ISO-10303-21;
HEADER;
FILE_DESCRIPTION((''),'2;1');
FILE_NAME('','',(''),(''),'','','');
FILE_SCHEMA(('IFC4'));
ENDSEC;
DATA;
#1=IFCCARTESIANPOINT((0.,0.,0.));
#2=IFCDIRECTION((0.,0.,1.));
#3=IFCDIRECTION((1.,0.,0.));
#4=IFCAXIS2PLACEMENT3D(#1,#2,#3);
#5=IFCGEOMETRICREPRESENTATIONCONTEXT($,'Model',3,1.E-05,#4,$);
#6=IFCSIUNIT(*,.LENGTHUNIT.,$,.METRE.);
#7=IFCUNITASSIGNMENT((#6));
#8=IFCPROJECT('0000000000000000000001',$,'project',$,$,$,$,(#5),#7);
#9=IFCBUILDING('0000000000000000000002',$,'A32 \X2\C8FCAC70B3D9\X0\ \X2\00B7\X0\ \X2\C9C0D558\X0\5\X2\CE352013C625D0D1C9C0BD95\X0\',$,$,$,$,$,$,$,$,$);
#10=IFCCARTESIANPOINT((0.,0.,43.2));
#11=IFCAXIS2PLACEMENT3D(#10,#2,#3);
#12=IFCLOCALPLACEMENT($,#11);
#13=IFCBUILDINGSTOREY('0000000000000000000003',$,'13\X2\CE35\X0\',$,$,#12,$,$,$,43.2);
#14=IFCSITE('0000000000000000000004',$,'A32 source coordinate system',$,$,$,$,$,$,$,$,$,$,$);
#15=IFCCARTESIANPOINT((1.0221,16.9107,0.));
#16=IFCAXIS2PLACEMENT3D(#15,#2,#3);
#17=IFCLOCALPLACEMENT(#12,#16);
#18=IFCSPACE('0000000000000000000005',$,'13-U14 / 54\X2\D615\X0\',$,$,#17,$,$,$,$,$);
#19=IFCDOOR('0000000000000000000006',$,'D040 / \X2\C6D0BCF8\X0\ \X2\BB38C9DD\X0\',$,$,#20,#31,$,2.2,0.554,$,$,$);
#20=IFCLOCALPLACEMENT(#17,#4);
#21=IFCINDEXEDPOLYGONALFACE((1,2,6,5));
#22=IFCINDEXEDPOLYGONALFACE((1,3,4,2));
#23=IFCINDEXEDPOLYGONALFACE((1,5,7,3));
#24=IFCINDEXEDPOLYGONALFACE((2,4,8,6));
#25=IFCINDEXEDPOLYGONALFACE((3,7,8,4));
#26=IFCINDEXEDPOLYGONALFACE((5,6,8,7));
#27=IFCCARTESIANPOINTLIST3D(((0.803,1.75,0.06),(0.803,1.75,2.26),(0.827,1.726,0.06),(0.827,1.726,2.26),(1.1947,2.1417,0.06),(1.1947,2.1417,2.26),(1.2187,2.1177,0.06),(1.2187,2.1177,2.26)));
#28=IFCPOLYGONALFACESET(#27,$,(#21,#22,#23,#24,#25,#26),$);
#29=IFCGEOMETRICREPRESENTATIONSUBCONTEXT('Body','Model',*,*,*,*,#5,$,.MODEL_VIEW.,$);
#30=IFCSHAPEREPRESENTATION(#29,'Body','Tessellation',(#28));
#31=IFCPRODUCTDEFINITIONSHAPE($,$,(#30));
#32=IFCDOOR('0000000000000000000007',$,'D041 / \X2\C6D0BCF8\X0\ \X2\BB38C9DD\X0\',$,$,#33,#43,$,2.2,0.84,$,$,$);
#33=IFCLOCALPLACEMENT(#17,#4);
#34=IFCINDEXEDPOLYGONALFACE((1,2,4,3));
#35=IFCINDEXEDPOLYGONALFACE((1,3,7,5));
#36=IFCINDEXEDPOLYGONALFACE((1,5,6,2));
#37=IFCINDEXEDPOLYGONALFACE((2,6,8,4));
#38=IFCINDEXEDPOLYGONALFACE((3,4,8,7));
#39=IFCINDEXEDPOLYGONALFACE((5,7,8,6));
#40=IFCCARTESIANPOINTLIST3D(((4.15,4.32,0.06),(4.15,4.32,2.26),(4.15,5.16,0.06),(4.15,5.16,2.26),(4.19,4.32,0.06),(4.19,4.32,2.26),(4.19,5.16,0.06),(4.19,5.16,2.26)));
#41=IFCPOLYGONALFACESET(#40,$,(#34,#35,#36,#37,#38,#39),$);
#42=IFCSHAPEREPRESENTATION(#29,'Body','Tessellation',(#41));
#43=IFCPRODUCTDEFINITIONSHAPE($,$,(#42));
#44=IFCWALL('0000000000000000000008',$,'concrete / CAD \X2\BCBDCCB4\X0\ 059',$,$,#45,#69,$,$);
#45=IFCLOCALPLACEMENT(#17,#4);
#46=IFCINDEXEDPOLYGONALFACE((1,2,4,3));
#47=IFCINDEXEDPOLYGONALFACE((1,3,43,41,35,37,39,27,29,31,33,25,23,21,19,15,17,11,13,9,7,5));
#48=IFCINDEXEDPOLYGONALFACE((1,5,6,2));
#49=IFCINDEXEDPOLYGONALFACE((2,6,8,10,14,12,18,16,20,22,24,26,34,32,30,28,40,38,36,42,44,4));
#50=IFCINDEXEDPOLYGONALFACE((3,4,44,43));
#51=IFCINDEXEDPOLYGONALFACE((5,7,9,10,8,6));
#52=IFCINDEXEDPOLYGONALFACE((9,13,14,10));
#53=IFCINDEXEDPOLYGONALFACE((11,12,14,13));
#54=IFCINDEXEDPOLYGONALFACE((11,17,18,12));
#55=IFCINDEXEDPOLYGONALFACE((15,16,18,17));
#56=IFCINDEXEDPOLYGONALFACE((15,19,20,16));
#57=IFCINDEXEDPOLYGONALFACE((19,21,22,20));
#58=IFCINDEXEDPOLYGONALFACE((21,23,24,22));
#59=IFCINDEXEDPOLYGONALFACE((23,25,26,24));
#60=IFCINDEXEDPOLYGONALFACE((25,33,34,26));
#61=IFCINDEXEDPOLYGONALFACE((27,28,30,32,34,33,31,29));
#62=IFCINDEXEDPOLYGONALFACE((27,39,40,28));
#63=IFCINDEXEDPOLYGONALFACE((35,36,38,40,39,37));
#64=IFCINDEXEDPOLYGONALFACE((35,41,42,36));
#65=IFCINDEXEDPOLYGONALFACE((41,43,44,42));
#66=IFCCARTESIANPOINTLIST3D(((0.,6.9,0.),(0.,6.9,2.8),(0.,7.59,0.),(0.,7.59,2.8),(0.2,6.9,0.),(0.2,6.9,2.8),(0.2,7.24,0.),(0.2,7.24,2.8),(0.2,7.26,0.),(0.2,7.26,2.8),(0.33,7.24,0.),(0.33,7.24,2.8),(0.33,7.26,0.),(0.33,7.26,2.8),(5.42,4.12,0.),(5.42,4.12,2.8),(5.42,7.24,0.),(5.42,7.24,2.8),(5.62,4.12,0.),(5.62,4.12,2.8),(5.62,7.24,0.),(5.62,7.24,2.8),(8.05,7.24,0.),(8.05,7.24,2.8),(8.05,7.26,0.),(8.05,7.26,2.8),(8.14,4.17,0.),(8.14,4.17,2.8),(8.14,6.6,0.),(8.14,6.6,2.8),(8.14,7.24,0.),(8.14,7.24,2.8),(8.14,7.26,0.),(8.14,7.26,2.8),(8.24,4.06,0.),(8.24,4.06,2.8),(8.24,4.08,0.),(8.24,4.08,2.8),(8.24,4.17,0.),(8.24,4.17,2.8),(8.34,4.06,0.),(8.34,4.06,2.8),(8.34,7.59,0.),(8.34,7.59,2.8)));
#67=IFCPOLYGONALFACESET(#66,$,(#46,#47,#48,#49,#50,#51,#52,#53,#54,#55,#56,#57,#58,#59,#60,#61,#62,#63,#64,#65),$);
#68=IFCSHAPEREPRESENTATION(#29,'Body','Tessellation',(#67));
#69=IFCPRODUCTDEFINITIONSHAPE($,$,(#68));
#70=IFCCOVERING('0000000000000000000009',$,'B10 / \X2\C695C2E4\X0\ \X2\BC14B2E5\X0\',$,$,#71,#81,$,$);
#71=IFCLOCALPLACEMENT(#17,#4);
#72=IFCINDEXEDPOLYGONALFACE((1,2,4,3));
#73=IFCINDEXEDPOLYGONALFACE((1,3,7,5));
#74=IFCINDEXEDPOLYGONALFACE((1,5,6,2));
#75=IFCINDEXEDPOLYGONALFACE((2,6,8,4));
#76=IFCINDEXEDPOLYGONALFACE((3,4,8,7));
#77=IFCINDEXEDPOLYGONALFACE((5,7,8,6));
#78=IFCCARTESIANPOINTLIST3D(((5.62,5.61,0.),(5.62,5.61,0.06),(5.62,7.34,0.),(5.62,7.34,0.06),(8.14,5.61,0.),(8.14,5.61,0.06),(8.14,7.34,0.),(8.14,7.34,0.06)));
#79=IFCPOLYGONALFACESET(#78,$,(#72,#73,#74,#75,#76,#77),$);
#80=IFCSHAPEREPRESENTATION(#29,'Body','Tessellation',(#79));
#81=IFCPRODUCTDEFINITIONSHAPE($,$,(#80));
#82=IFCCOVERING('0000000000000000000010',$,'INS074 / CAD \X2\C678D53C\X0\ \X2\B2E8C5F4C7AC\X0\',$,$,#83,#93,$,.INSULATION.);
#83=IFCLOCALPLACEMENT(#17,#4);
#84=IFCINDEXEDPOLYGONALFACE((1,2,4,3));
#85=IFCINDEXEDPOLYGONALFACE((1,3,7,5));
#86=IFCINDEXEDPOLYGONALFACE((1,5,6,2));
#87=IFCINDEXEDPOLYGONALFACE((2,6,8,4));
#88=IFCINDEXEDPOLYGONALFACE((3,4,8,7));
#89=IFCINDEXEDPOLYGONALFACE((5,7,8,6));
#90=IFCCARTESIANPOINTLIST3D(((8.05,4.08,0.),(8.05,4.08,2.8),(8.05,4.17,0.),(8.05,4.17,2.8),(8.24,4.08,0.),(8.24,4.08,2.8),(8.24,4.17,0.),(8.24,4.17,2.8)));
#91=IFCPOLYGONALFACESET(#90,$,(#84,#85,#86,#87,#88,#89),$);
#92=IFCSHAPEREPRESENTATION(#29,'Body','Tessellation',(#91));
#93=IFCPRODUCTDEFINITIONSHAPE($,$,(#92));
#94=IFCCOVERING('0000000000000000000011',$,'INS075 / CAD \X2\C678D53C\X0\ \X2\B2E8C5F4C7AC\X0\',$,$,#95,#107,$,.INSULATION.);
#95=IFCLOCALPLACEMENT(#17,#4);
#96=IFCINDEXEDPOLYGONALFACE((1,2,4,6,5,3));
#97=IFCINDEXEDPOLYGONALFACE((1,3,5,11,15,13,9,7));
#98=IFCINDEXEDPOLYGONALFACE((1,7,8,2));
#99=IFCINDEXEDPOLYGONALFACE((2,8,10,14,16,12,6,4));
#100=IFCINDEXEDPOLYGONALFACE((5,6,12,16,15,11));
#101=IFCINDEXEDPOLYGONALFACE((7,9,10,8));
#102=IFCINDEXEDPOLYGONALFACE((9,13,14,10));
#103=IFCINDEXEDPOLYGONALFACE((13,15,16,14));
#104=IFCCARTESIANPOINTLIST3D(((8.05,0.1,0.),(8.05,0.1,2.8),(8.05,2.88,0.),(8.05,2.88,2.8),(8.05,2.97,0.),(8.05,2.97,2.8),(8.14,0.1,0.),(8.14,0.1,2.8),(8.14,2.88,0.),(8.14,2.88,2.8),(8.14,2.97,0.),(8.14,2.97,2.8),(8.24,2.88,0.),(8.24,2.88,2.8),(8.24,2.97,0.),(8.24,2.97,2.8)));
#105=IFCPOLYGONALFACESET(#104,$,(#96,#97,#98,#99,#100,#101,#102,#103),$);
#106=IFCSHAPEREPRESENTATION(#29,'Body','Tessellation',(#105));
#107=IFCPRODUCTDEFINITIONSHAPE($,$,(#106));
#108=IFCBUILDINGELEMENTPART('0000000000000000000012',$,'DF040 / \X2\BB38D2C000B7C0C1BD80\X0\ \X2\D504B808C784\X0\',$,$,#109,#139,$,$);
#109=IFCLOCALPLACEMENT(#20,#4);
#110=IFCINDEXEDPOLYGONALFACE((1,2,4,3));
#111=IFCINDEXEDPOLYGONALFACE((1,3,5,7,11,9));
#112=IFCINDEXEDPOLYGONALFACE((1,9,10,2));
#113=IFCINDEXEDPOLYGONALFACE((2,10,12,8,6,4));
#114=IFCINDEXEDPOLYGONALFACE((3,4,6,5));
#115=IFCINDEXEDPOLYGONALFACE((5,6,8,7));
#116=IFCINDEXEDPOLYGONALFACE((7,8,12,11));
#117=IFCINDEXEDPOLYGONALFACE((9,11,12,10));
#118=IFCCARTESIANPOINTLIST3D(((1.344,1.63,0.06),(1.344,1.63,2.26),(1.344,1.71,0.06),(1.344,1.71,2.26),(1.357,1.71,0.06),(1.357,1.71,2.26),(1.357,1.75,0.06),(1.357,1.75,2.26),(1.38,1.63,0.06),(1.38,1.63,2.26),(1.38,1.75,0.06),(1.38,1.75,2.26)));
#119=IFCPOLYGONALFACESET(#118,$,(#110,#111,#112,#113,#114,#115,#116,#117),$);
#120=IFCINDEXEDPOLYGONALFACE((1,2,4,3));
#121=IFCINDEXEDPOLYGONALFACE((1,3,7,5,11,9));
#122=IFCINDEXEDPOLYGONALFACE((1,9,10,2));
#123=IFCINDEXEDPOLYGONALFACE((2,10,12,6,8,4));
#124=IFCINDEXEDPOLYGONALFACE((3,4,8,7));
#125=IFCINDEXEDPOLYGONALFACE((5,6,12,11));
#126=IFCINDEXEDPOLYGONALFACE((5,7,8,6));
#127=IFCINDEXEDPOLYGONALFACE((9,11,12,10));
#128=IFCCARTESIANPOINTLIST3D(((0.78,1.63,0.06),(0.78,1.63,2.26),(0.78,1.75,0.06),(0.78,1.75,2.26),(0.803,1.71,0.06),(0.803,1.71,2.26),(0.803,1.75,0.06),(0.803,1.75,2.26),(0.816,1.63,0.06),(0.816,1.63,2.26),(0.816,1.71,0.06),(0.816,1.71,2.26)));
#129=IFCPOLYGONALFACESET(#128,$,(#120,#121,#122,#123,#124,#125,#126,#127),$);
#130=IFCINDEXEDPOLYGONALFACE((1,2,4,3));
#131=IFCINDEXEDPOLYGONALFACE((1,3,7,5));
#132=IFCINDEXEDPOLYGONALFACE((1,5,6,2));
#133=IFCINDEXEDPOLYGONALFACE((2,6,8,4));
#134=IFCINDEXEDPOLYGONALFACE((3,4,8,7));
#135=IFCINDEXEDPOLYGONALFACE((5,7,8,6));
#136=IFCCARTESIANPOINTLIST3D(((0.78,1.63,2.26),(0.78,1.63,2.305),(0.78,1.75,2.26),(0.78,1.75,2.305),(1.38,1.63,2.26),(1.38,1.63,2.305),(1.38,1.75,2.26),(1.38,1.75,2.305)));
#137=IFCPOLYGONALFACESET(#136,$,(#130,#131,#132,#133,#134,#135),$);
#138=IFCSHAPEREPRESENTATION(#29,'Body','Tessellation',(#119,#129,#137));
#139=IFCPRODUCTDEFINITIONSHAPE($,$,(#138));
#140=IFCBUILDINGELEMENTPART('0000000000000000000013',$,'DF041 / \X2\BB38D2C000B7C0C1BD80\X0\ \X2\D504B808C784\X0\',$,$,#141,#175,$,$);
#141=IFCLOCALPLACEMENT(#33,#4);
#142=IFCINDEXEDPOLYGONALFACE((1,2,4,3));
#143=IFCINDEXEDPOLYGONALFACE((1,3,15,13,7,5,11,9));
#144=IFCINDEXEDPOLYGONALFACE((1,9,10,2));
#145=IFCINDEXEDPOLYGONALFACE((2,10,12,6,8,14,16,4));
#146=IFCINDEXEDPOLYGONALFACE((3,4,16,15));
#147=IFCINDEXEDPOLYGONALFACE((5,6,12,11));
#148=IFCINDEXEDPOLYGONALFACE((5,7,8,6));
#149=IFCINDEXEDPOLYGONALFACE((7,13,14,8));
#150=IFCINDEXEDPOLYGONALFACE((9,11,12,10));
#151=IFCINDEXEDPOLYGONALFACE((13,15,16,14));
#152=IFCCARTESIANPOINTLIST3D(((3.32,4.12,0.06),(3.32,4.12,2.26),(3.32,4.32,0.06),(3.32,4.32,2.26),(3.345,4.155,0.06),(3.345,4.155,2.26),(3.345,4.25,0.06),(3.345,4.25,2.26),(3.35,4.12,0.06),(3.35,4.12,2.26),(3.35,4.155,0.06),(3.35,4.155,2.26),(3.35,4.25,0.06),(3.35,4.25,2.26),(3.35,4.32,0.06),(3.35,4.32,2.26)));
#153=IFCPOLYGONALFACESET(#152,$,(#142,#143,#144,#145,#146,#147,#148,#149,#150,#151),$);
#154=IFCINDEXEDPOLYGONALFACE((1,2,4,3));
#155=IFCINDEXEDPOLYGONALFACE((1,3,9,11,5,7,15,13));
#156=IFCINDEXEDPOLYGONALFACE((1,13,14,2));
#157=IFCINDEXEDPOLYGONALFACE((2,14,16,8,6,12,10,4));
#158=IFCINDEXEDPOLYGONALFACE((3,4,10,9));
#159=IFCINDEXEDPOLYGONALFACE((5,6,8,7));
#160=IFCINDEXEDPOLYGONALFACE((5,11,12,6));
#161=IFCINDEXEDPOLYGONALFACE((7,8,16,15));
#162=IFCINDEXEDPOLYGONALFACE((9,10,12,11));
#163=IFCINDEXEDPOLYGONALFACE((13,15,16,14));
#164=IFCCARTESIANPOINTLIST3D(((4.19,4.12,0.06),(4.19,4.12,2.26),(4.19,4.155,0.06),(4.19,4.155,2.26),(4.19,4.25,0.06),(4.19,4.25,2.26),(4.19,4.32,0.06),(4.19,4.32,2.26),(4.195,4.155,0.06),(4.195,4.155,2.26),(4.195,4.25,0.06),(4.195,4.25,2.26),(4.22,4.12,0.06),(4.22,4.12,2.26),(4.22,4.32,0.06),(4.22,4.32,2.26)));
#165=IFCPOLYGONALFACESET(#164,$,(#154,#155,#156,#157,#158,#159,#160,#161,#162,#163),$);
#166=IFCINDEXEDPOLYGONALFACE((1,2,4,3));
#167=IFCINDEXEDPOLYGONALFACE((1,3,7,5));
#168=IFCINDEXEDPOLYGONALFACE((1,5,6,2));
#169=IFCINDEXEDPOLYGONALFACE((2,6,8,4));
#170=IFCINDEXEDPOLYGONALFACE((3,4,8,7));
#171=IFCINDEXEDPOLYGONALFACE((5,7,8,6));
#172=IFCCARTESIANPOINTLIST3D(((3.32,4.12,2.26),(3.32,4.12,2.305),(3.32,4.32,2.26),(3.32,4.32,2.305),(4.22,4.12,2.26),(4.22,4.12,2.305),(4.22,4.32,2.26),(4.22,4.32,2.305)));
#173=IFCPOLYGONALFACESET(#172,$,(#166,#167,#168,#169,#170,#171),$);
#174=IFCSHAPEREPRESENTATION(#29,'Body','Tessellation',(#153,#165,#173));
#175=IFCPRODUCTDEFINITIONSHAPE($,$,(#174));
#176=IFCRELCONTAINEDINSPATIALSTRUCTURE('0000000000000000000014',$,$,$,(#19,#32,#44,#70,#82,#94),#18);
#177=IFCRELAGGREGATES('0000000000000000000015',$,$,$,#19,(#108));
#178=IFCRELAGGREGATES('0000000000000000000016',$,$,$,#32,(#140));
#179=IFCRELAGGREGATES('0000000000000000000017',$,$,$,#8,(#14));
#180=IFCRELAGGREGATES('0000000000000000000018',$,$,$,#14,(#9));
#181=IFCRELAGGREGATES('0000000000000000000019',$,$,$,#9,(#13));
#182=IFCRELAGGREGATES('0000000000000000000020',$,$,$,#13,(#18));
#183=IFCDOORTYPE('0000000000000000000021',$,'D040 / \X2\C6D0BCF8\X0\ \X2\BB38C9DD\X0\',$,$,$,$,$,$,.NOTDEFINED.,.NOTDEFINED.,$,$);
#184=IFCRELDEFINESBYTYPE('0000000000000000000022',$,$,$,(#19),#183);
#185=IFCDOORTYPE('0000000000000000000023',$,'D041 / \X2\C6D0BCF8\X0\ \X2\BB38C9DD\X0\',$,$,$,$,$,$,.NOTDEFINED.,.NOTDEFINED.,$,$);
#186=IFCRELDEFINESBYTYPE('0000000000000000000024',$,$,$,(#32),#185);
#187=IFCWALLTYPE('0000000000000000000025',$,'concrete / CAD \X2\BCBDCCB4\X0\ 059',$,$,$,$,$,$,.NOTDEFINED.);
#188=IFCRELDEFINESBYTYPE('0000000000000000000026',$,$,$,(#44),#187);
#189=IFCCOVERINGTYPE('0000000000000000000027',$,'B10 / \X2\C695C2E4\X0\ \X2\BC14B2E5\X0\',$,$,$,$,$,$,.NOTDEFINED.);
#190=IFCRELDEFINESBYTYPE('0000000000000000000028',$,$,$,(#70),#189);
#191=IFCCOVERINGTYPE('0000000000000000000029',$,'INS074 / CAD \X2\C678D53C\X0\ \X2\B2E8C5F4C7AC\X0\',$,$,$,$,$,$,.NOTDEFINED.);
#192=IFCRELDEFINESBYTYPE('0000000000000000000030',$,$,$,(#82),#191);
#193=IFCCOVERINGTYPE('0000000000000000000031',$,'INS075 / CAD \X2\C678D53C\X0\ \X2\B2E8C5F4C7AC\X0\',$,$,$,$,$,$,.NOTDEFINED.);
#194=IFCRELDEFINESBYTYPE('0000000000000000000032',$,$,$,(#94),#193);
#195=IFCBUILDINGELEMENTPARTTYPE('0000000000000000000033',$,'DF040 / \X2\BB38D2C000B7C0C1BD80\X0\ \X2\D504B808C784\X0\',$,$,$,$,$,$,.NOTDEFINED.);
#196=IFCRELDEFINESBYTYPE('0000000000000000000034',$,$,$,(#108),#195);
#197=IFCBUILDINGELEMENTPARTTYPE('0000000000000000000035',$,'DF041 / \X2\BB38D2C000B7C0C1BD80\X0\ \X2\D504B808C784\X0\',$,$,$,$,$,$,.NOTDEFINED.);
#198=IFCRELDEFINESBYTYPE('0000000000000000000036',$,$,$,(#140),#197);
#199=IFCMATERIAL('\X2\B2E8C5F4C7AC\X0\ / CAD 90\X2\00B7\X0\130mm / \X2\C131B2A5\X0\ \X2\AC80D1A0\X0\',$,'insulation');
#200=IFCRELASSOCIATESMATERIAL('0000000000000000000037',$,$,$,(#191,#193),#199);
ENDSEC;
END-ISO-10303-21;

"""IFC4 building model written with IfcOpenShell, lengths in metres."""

from ifc_helpers import new_model, si_unit, frame, origin, origin_with_axes, place, context, subcontext, project, spatial, polyline, outline, extrude, source, transform, mapped, material, type_object, type_shapes, element, aggregate, save


model = new_model("IFC4")

# Units and contexts
model_context = context("Model", 3, precision=1e-05, world=origin_with_axes())
body_context = subcontext(model_context, "Body", "Model", "MODEL_VIEW")
ifc_project = project(units=[si_unit("LENGTHUNIT", "METRE")], contexts=[model_context])

# Site, building, storey, space
storey_placement = place(None, frame((0.0, 0.0, 43.2), z_axis=(0.0, 0.0, 1.0), x_axis=(1.0, 0.0, 0.0)))
space_1_placement = place(storey_placement, frame((1.0221, 16.9107, 0.0), z_axis=(0.0, 0.0, 1.0), x_axis=(1.0, 0.0, 0.0)))
site = spatial("IfcSite", under=ifc_project, Name="A32 source coordinate system")
building = spatial("IfcBuilding", under=site, Name="A32 주거동 · 지하5층–옥탑지붕")
storey = spatial("IfcBuildingStorey", under=building, at=storey_placement, Name="13층", Elevation=43.2)
space_1 = spatial("IfcSpace", under=storey, at=space_1_placement, Name="13-U14 / 54형")

# Doors
door_type_1 = type_object("IfcDoorType", Name="D040 / 원본 문짝", OperationType="NOTDEFINED", PredefinedType="NOTDEFINED")
shared_shape_1 = source(origin(), body_context, "Body", "SweptSolid", [
    extrude(outline(polyline([(0.803, 1.75), (1.1947, 2.1417), (1.2187, 2.1177), (0.827, 1.726), (0.803, 1.75)])), frame((0.0, 0.0, 0.06)), (0.0, 0.0, 1.0), 2.2),
])
type_shapes(door_type_1, [shared_shape_1])
door_1_placement = place(space_1_placement, origin_with_axes())
door_1 = element("IfcDoor", 1, at=door_1_placement, inside=space_1, type_object=door_type_1, Name="D040 / 원본 문짝", OverallHeight=2.2, OverallWidth=0.554, context=body_context, shape_type="MappedRepresentation", body=[
    mapped(shared_shape_1, transform((0.0, 0.0, 0.0), scale=1.0)),
])
door_type_2 = type_object("IfcDoorType", Name="D041 / 원본 문짝", OperationType="NOTDEFINED", PredefinedType="NOTDEFINED")
shared_shape_2 = source(origin(), body_context, "Body", "SweptSolid", [
    extrude(outline(polyline([(4.15, 5.16), (4.19, 5.16), (4.19, 4.32), (4.15, 4.32), (4.15, 5.16)])), frame((0.0, 0.0, 0.06)), (0.0, 0.0, 1.0), 2.2),
])
type_shapes(door_type_2, [shared_shape_2])
door_2_placement = place(space_1_placement, origin_with_axes())
door_2 = element("IfcDoor", 2, at=door_2_placement, inside=space_1, type_object=door_type_2, Name="D041 / 원본 문짝", OverallHeight=2.2, OverallWidth=0.84, context=body_context, shape_type="MappedRepresentation", body=[
    mapped(shared_shape_2, transform((0.0, 0.0, 0.0), scale=1.0)),
])

# Wall
wall_type_1 = type_object("IfcWallType", Name="concrete / CAD 벽체 059", PredefinedType="NOTDEFINED")
shared_shape_3 = source(origin(), body_context, "Body", "SweptSolid", [
    extrude(outline(polyline([(8.05, 7.26), (8.05, 7.24), (5.62, 7.24), (5.62, 4.12), (5.42, 4.12), (5.42, 7.24), (0.33, 7.24), (0.33, 7.26), (0.2, 7.26), (0.2, 7.24), (0.2, 6.9), (0.0, 6.9), (0.0, 7.59), (8.34, 7.59), (8.34, 4.06), (8.24, 4.06), (8.24, 4.08), (8.24, 4.17), (8.14, 4.17), (8.14, 6.6), (8.14, 7.24), (8.14, 7.26), (8.05, 7.26)])), origin(), (0.0, 0.0, 1.0), 2.8),
])
type_shapes(wall_type_1, [shared_shape_3])
wall_1_placement = place(space_1_placement, origin_with_axes())
element("IfcWall", 3, at=wall_1_placement, inside=space_1, type_object=wall_type_1, Name="concrete / CAD 벽체 059", context=body_context, shape_type="MappedRepresentation", body=[
    mapped(shared_shape_3, transform((0.0, 0.0, 0.0), scale=1.0)),
])

# Coverings
covering_type_1 = type_object("IfcCoveringType", Name="B10 / 욕실 바닥", PredefinedType="NOTDEFINED")
shared_shape_4 = source(origin(), body_context, "Body", "SweptSolid", [
    extrude(outline(polyline([(8.14, 5.61), (5.62, 5.61), (5.62, 7.34), (8.14, 7.34), (8.14, 5.61)])), origin(), (0.0, 0.0, 1.0), 0.06),
])
type_shapes(covering_type_1, [shared_shape_4])
covering_1_placement = place(space_1_placement, origin_with_axes())
element("IfcCovering", 4, at=covering_1_placement, inside=space_1, type_object=covering_type_1, Name="B10 / 욕실 바닥", context=body_context, shape_type="MappedRepresentation", body=[
    mapped(shared_shape_4, transform((0.0, 0.0, 0.0), scale=1.0)),
])
ifc_material = material(Name="단열재 / CAD 90·130mm / 성능 검토", Category="insulation")
covering_type_2 = type_object("IfcCoveringType", Name="INS074 / CAD 외피 단열재", PredefinedType="NOTDEFINED", material=ifc_material)
shared_shape_5 = source(origin(), body_context, "Body", "SweptSolid", [
    extrude(outline(polyline([(8.05, 4.08), (8.05, 4.17), (8.24, 4.17), (8.24, 4.08), (8.05, 4.08)])), origin(), (0.0, 0.0, 1.0), 2.8),
])
type_shapes(covering_type_2, [shared_shape_5])
covering_2_placement = place(space_1_placement, origin_with_axes())
element("IfcCovering", 5, at=covering_2_placement, inside=space_1, type_object=covering_type_2, Name="INS074 / CAD 외피 단열재", PredefinedType="INSULATION", context=body_context, shape_type="MappedRepresentation", body=[
    mapped(shared_shape_5, transform((0.0, 0.0, 0.0), scale=1.0)),
])
covering_type_3 = type_object("IfcCoveringType", Name="INS075 / CAD 외피 단열재", PredefinedType="NOTDEFINED", material=ifc_material)
shared_shape_6 = source(origin(), body_context, "Body", "SweptSolid", [
    extrude(outline(polyline([(8.24, 2.88), (8.14, 2.88), (8.14, 0.1), (8.05, 0.1), (8.05, 2.88), (8.05, 2.97), (8.14, 2.97), (8.24, 2.97), (8.24, 2.88)])), origin(), (0.0, 0.0, 1.0), 2.8),
])
type_shapes(covering_type_3, [shared_shape_6])
covering_3_placement = place(space_1_placement, origin_with_axes())
element("IfcCovering", 6, at=covering_3_placement, inside=space_1, type_object=covering_type_3, Name="INS075 / CAD 외피 단열재", PredefinedType="INSULATION", context=body_context, shape_type="MappedRepresentation", body=[
    mapped(shared_shape_6, transform((0.0, 0.0, 0.0), scale=1.0)),
])

# Building element parts
building_element_part_type_1 = type_object("IfcBuildingElementPartType", Name="DF040 / 문틀·상부 프레임", PredefinedType="NOTDEFINED")
shared_shape_7 = source(origin(), body_context, "Body", "SweptSolid", [
    extrude(outline(polyline([(1.344, 1.63), (1.344, 1.71), (1.357, 1.71), (1.357, 1.75), (1.38, 1.75), (1.38, 1.63), (1.344, 1.63)])), frame((0.0, 0.0, 0.06)), (0.0, 0.0, 1.0), 2.2),
    extrude(outline(polyline([(0.78, 1.75), (0.803, 1.75), (0.803, 1.71), (0.816, 1.71), (0.816, 1.63), (0.78, 1.63), (0.78, 1.75)])), frame((0.0, 0.0, 0.06)), (0.0, 0.0, 1.0), 2.2),
    extrude(outline(polyline([(0.78, 1.63), (0.78, 1.75), (1.38, 1.75), (1.38, 1.63), (0.78, 1.63)])), frame((0.0, 0.0, 2.26)), (0.0, 0.0, 1.0), 0.045),
])
type_shapes(building_element_part_type_1, [shared_shape_7])
building_element_part_1_placement = place(door_1_placement, origin_with_axes())
building_element_part_1 = element("IfcBuildingElementPart", 7, at=building_element_part_1_placement, type_object=building_element_part_type_1, Name="DF040 / 문틀·상부 프레임", context=body_context, shape_type="MappedRepresentation", body=[
    mapped(shared_shape_7, transform((0.0, 0.0, 0.0), scale=1.0)),
])
aggregate(door_1, [building_element_part_1])
building_element_part_type_2 = type_object("IfcBuildingElementPartType", Name="DF041 / 문틀·상부 프레임", PredefinedType="NOTDEFINED")
shared_shape_8 = source(origin(), body_context, "Body", "SweptSolid", [
    extrude(outline(polyline([(3.35, 4.32), (3.35, 4.25), (3.345, 4.25), (3.345, 4.155), (3.35, 4.155), (3.35, 4.12), (3.32, 4.12), (3.32, 4.32), (3.35, 4.32)])), frame((0.0, 0.0, 0.06)), (0.0, 0.0, 1.0), 2.2),
    extrude(outline(polyline([(4.22, 4.12), (4.19, 4.12), (4.19, 4.155), (4.195, 4.155), (4.195, 4.25), (4.19, 4.25), (4.19, 4.32), (4.22, 4.32), (4.22, 4.12)])), frame((0.0, 0.0, 0.06)), (0.0, 0.0, 1.0), 2.2),
    extrude(outline(polyline([(3.32, 4.12), (3.32, 4.32), (4.22, 4.32), (4.22, 4.12), (3.32, 4.12)])), frame((0.0, 0.0, 2.26)), (0.0, 0.0, 1.0), 0.045),
])
type_shapes(building_element_part_type_2, [shared_shape_8])
building_element_part_2_placement = place(door_2_placement, origin_with_axes())
building_element_part_2 = element("IfcBuildingElementPart", 8, at=building_element_part_2_placement, type_object=building_element_part_type_2, Name="DF041 / 문틀·상부 프레임", context=body_context, shape_type="MappedRepresentation", body=[
    mapped(shared_shape_8, transform((0.0, 0.0, 0.0), scale=1.0)),
])
aggregate(door_2, [building_element_part_2])

save(model, "model.ifc")
